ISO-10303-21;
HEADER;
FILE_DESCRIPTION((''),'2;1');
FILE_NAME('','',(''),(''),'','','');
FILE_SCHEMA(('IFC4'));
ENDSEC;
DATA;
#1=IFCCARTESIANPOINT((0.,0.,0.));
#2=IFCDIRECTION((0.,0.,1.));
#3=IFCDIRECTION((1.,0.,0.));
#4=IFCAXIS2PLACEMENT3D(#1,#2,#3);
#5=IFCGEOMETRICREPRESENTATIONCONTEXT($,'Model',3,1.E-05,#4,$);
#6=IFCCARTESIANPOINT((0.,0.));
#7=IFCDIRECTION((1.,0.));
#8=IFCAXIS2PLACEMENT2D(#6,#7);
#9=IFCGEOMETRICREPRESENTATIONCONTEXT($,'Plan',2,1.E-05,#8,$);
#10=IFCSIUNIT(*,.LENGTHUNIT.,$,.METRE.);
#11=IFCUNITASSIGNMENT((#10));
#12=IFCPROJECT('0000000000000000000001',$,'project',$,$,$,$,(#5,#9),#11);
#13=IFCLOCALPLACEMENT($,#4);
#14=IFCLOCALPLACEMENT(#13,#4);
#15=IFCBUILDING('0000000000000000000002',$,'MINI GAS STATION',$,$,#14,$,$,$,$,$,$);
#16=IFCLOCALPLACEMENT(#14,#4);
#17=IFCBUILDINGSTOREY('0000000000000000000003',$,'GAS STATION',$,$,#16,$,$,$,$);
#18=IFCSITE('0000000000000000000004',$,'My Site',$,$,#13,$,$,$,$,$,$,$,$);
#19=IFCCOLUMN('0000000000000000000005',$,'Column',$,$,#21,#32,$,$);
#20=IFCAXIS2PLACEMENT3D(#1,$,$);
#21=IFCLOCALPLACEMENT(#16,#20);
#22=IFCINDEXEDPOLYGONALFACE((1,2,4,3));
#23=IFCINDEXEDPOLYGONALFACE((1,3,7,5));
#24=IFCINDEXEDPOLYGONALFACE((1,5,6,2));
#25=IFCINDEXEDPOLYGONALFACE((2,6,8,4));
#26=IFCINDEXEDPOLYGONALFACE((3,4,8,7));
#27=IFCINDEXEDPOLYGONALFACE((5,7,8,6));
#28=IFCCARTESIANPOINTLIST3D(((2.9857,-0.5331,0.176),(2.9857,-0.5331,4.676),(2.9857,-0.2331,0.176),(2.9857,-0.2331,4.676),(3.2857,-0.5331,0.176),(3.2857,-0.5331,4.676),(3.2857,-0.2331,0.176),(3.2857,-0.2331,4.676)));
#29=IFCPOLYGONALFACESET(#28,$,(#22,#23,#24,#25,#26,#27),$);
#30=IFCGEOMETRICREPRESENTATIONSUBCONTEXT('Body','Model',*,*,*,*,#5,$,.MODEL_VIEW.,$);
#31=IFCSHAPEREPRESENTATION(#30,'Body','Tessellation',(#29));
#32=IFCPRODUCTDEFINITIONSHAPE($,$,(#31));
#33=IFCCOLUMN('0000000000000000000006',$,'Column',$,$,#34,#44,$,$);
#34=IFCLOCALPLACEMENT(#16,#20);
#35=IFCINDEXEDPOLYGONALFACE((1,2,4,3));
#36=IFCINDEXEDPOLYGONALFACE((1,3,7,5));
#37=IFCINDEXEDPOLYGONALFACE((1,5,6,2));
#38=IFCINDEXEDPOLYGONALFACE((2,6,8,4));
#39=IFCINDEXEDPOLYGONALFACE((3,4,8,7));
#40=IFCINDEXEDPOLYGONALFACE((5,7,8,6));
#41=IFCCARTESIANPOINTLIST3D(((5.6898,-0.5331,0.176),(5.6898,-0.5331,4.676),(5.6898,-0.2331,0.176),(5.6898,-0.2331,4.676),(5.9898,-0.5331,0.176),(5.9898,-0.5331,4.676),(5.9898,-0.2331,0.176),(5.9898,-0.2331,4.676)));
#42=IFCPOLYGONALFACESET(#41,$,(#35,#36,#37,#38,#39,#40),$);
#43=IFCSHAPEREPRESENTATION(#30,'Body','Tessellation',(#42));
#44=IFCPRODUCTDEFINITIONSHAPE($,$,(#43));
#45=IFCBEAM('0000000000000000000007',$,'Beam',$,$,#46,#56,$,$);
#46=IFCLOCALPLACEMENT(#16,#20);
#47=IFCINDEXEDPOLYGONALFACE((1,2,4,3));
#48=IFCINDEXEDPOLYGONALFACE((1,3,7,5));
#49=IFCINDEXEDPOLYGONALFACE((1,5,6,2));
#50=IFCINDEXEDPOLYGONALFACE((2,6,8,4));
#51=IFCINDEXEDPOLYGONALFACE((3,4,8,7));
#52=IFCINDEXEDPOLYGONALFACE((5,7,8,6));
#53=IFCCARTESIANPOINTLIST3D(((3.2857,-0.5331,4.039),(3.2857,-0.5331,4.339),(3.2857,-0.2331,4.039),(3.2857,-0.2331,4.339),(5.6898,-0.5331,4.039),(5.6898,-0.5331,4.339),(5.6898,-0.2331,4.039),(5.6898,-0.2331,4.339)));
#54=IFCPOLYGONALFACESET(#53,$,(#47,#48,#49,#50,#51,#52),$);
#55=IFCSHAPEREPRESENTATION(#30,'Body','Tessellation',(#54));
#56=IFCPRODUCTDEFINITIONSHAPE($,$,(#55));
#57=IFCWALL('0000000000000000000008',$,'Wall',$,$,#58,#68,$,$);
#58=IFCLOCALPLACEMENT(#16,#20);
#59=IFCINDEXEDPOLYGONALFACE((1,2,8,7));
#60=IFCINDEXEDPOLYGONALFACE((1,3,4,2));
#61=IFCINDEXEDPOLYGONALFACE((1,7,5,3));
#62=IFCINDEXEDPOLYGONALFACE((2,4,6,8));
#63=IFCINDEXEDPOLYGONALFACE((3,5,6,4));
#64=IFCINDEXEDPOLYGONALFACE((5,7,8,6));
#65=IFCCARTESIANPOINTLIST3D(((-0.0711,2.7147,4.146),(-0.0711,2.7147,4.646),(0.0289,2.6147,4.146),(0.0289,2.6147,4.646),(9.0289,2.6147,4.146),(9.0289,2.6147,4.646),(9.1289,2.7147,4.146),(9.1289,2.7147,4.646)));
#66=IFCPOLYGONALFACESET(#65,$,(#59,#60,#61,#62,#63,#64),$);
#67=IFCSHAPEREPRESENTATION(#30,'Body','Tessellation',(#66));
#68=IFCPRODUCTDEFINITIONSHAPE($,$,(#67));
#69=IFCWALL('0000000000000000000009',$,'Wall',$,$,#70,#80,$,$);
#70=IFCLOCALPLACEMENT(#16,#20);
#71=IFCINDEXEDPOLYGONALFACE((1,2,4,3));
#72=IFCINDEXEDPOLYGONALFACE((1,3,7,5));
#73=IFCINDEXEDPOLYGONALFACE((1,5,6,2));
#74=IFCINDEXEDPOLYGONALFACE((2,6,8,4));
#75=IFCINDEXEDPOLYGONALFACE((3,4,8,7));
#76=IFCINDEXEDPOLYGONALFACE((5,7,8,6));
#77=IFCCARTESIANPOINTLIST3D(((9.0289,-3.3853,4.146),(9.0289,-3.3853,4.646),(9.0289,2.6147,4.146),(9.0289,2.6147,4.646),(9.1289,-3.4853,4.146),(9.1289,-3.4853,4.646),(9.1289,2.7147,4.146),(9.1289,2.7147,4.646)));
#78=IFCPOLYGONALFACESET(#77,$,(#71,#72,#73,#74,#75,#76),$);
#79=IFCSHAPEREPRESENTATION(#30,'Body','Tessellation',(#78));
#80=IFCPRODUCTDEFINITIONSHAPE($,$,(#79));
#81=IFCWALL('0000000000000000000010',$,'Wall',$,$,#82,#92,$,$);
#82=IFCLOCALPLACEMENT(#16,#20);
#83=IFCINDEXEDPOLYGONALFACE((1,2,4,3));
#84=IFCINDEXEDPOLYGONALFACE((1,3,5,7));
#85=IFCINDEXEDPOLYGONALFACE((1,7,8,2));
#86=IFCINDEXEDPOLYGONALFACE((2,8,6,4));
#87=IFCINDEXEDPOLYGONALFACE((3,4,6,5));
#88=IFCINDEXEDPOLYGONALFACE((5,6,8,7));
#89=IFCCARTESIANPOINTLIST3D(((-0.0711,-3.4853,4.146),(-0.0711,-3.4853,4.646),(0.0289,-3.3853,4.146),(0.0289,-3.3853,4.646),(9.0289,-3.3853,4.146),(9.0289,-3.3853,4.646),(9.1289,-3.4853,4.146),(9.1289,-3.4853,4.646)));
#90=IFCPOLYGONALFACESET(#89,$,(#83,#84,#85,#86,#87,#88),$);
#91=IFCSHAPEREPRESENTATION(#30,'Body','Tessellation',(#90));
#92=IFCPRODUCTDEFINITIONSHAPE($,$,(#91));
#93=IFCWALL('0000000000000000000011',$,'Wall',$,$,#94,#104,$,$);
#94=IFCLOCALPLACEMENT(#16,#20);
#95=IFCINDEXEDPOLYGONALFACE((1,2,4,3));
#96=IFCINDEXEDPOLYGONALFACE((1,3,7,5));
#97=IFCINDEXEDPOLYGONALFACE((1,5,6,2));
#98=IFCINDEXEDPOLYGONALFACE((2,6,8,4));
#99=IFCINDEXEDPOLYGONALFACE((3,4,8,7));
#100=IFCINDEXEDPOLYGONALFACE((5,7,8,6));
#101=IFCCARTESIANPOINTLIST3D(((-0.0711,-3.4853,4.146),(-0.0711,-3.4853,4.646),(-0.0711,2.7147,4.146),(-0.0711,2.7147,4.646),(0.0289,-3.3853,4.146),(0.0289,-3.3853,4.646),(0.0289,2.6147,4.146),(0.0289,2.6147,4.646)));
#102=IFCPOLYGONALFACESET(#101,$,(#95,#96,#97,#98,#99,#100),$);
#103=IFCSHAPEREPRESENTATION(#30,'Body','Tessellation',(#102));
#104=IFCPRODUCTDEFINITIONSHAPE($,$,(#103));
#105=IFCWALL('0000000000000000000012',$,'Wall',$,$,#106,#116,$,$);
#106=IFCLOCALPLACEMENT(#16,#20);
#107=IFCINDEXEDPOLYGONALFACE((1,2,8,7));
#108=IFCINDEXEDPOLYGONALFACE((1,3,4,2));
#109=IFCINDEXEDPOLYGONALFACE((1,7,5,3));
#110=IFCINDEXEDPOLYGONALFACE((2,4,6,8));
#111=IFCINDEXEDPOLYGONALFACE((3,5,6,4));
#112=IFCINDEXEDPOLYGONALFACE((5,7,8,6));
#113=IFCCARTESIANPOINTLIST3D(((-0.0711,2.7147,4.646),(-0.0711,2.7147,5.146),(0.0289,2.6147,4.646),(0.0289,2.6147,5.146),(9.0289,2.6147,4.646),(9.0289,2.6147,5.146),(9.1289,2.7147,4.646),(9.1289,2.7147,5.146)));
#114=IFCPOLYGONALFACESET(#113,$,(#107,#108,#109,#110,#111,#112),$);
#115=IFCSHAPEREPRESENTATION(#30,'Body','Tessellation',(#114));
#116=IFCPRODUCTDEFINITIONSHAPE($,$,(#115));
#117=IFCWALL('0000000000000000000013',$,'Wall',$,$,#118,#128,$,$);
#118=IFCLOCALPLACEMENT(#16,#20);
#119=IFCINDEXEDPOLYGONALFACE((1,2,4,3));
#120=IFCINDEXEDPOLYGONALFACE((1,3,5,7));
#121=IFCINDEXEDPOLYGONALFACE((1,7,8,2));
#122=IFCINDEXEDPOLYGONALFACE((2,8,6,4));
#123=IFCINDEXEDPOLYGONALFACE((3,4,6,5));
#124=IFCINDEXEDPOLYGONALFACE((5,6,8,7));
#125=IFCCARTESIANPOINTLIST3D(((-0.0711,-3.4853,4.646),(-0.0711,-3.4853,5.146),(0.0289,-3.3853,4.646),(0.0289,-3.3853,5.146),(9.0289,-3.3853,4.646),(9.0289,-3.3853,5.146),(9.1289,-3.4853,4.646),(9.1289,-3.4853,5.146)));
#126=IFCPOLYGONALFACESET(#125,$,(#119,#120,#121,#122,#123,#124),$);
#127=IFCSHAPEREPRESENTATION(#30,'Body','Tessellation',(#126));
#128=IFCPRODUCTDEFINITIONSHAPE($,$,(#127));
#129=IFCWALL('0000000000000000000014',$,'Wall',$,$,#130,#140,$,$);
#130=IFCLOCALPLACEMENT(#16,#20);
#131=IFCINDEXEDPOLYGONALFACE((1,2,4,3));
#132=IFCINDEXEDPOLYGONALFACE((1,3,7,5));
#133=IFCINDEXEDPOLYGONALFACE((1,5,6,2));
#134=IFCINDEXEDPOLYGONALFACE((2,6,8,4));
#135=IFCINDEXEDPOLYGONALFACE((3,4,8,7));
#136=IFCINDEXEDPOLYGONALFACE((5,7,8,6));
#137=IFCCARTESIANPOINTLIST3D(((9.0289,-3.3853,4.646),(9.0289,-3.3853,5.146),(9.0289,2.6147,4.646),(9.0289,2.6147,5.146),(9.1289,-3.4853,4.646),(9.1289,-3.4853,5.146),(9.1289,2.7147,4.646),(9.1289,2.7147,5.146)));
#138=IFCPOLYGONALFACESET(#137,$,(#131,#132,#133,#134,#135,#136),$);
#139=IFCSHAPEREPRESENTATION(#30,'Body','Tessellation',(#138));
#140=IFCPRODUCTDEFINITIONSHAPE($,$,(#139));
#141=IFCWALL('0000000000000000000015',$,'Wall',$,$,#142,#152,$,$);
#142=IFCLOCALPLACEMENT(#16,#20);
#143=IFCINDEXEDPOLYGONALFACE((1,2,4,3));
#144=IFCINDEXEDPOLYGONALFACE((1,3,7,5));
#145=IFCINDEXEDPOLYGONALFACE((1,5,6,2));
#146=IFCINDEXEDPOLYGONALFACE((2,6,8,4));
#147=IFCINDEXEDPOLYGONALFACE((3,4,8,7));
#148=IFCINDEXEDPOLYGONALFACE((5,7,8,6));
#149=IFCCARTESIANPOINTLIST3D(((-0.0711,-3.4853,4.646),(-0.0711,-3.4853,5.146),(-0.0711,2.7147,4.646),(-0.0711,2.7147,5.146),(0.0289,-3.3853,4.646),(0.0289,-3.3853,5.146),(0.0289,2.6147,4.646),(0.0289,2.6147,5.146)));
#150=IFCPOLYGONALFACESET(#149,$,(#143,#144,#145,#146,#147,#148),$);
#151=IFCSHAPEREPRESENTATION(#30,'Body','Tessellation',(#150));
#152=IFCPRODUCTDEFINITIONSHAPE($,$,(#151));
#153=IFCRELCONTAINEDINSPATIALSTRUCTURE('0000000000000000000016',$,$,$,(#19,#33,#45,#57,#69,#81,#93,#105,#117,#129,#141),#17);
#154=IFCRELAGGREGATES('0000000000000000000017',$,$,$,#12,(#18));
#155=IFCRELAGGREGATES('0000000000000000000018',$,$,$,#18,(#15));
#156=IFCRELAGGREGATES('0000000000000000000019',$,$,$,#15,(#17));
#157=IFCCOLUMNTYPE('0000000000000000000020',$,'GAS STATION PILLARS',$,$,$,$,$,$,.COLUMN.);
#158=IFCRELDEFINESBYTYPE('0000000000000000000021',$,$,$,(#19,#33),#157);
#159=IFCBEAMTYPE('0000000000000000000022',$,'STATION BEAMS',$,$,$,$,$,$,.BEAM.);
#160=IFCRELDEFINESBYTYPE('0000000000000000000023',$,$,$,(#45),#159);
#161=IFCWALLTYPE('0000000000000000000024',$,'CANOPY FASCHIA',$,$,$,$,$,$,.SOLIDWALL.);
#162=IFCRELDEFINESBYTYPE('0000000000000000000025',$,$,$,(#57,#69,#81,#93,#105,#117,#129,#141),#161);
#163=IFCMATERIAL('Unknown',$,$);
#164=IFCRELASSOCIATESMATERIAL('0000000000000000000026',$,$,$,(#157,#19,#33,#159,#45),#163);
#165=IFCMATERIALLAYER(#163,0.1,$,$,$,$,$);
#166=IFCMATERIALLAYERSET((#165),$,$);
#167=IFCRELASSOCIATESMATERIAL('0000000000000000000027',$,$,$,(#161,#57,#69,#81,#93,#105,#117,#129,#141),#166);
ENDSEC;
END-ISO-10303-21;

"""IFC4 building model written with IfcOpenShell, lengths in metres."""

from ifc_helpers import new_model, si_unit, frame, origin_with_axes, origin_2d_with_axis, place, context, subcontext, project, spatial, line, indexed_curve, rectangle, outline, extrude, material, layer, layer_set, layer_usage, material_profile, profile_set, profile_usage, type_object, element, save


model = new_model("IFC4")

# Units and contexts
model_context = context("Model", 3, precision=1e-05, world=origin_with_axes())
plan_context = context("Plan", 2, precision=1e-05, world=origin_2d_with_axis())
body_context = subcontext(model_context, "Body", "Model", "MODEL_VIEW")
ifc_project = project(units=[si_unit("LENGTHUNIT", "METRE")], contexts=[model_context, plan_context])

# Site, building, storey
site_placement = place(None, origin_with_axes())
site = spatial("IfcSite", under=ifc_project, at=site_placement, Name="My Site")
building_placement = place(site_placement, origin_with_axes())
building = spatial("IfcBuilding", under=site, at=building_placement, Name="MINI GAS STATION")
storey_placement = place(building_placement, origin_with_axes())
storey = spatial("IfcBuildingStorey", under=building, at=storey_placement, Name="GAS STATION")

# Columns
ifc_material = material(Name="Unknown")
ifc_material_profile_1 = material_profile(ifc_material, rectangle(XDim=0.3, YDim=0.3))
ifc_profile_set_1 = profile_set([ifc_material_profile_1])
ifc_profile_usage_1 = profile_usage(ifc_profile_set_1, cardinal=5)
column_type = type_object("IfcColumnType", Name="GAS STATION PILLARS", PredefinedType="COLUMN", material=ifc_profile_set_1)
column_1_placement = place(storey_placement, frame((3.1357, -0.3831, 0.176), z_axis=(0.0, 0.0, 1.0), x_axis=(1.0, 0.0, 0.0)))
element("IfcColumn", 1, at=column_1_placement, inside=storey, type_object=column_type, material=ifc_profile_usage_1, Name="Column", context=body_context, shape_type="SweptSolid", body=[
    extrude(rectangle(XDim=0.3, YDim=0.3), origin_with_axes(), (0.0, 0.0, 1.0), 4.5),
])
ifc_profile_usage_2 = profile_usage(ifc_profile_set_1, cardinal=5)
column_2_placement = place(storey_placement, frame((5.8398, -0.3831, 0.176), z_axis=(0.0, 0.0, 1.0), x_axis=(1.0, 0.0, 0.0)))
element("IfcColumn", 2, at=column_2_placement, inside=storey, type_object=column_type, material=ifc_profile_usage_2, Name="Column", context=body_context, shape_type="SweptSolid", body=[
    extrude(rectangle(XDim=0.3, YDim=0.3), origin_with_axes(), (0.0, 0.0, 1.0), 4.5),
])

# Beam
ifc_material_profile_2 = material_profile(ifc_material, rectangle(XDim=0.3, YDim=0.3))
ifc_profile_set_2 = profile_set([ifc_material_profile_2])
ifc_profile_usage_3 = profile_usage(ifc_profile_set_2, cardinal=5)
beam_type = type_object("IfcBeamType", Name="STATION BEAMS", PredefinedType="BEAM", material=ifc_profile_set_2)
beam_placement = place(storey_placement, frame((3.2857, -0.3831, 4.189), z_axis=(1.0, 0.0, 0.0), x_axis=(0.0, 1.0, 0.0)))
element("IfcBeam", 3, at=beam_placement, inside=storey, type_object=beam_type, material=ifc_profile_usage_3, Name="Beam", context=body_context, shape_type="SweptSolid", body=[
    extrude(rectangle(XDim=0.3, YDim=0.3), origin_with_axes(), (0.0, 0.0, 1.0), 2.4041),
])

# Walls
ifc_layer_1 = layer(ifc_material, 0.1)
ifc_layer_set_1 = layer_set([ifc_layer_1])
ifc_layer_usage_1 = layer_usage(ifc_layer_set_1, "AXIS2", "POSITIVE", 0.0)
wall_type = type_object("IfcWallType", Name="CANOPY FASCHIA", PredefinedType="SOLIDWALL", material=ifc_layer_set_1)
wall_1_placement = place(storey_placement, frame((0.0289, 2.6147, 4.146), z_axis=(0.0, 0.0, 1.0), x_axis=(1.0, 0.0, 0.0)))
element("IfcWall", 4, at=wall_1_placement, inside=storey, type_object=wall_type, material=ifc_layer_usage_1, Name="Wall", context=body_context, shape_type="SweptSolid", body=[
    extrude(outline(indexed_curve([(0.0, 0.0), (-0.1, 0.1), (9.1, 0.1), (9.0, 0.0)], segments=[line(1, 2, 3, 4, 1)])), origin_with_axes(), (0.0, 0.0, 1.0), 0.5),
])
ifc_layer_usage_2 = layer_usage(ifc_layer_set_1, "AXIS2", "POSITIVE", 0.0)
wall_2_placement = place(storey_placement, frame((9.0289, 2.6147, 4.146), z_axis=(0.0, 0.0, 1.0), x_axis=(0.0, -1.0, 0.0)))
element("IfcWall", 5, at=wall_2_placement, inside=storey, type_object=wall_type, material=ifc_layer_usage_2, Name="Wall", context=body_context, shape_type="SweptSolid", body=[
    extrude(outline(indexed_curve([(0.0, 0.0), (-0.1, 0.1), (6.1, 0.1), (6.0, 0.0)], segments=[line(1, 2, 3, 4, 1)])), origin_with_axes(), (0.0, 0.0, 1.0), 0.5),
])
ifc_layer_usage_3 = layer_usage(ifc_layer_set_1, "AXIS2", "POSITIVE", 0.0)
wall_3_placement = place(storey_placement, frame((9.0289, -3.3853, 4.146), z_axis=(0.0, 0.0, 1.0), x_axis=(-1.0, 0.0, 0.0)))
element("IfcWall", 6, at=wall_3_placement, inside=storey, type_object=wall_type, material=ifc_layer_usage_3, Name="Wall", context=body_context, shape_type="SweptSolid", body=[
    extrude(outline(indexed_curve([(0.0, 0.0), (-0.1, 0.1), (9.1, 0.1), (9.0, 0.0)], segments=[line(1, 2, 3, 4, 1)])), origin_with_axes(), (0.0, 0.0, 1.0), 0.5),
])
ifc_layer_usage_4 = layer_usage(ifc_layer_set_1, "AXIS2", "POSITIVE", 0.0)
wall_4_placement = place(storey_placement, frame((0.0289, -3.3853, 4.146), z_axis=(0.0, 0.0, 1.0), x_axis=(0.0, 1.0, 0.0)))
element("IfcWall", 7, at=wall_4_placement, inside=storey, type_object=wall_type, material=ifc_layer_usage_4, Name="Wall", context=body_context, shape_type="SweptSolid", body=[
    extrude(outline(indexed_curve([(0.0, 0.0), (-0.1, 0.1), (6.1, 0.1), (6.0, 0.0)], segments=[line(1, 2, 3, 4, 1)])), origin_with_axes(), (0.0, 0.0, 1.0), 0.5),
])
ifc_layer_usage_5 = layer_usage(ifc_layer_set_1, "AXIS2", "POSITIVE", 0.0)
wall_5_placement = place(storey_placement, frame((0.0289, 2.6147, 4.646), z_axis=(0.0, 0.0, 1.0), x_axis=(1.0, 0.0, 0.0)))
element("IfcWall", 8, at=wall_5_placement, inside=storey, type_object=wall_type, material=ifc_layer_usage_5, Name="Wall", context=body_context, shape_type="SweptSolid", body=[
    extrude(outline(indexed_curve([(0.0, 0.0), (-0.1, 0.1), (9.1, 0.1), (9.0, 0.0)], segments=[line(1, 2, 3, 4, 1)])), origin_with_axes(), (0.0, 0.0, 1.0), 0.5),
])
ifc_layer_usage_6 = layer_usage(ifc_layer_set_1, "AXIS2", "POSITIVE", 0.0)
wall_6_placement = place(storey_placement, frame((9.0289, -3.3853, 4.646), z_axis=(0.0, 0.0, 1.0), x_axis=(-1.0, 0.0, 0.0)))
element("IfcWall", 9, at=wall_6_placement, inside=storey, type_object=wall_type, material=ifc_layer_usage_6, Name="Wall", context=body_context, shape_type="SweptSolid", body=[
    extrude(outline(indexed_curve([(0.0, 0.0), (-0.1, 0.1), (9.1, 0.1), (9.0, 0.0)], segments=[line(1, 2, 3, 4, 1)])), origin_with_axes(), (0.0, 0.0, 1.0), 0.5),
])
ifc_layer_usage_7 = layer_usage(ifc_layer_set_1, "AXIS2", "POSITIVE", 0.0)
wall_7_placement = place(storey_placement, frame((9.0289, 2.6147, 4.646), z_axis=(0.0, 0.0, 1.0), x_axis=(0.0, -1.0, 0.0)))
element("IfcWall", 10, at=wall_7_placement, inside=storey, type_object=wall_type, material=ifc_layer_usage_7, Name="Wall", context=body_context, shape_type="SweptSolid", body=[
    extrude(outline(indexed_curve([(0.0, 0.0), (-0.1, 0.1), (6.1, 0.1), (6.0, 0.0)], segments=[line(1, 2, 3, 4, 1)])), origin_with_axes(), (0.0, 0.0, 1.0), 0.5),
])
ifc_layer_usage_8 = layer_usage(ifc_layer_set_1, "AXIS2", "POSITIVE", 0.0)
wall_8_placement = place(storey_placement, frame((0.0289, -3.3853, 4.646), z_axis=(0.0, 0.0, 1.0), x_axis=(0.0, 1.0, 0.0)))
element("IfcWall", 11, at=wall_8_placement, inside=storey, type_object=wall_type, material=ifc_layer_usage_8, Name="Wall", context=body_context, shape_type="SweptSolid", body=[
    extrude(outline(indexed_curve([(0.0, 0.0), (-0.1, 0.1), (6.1, 0.1), (6.0, 0.0)], segments=[line(1, 2, 3, 4, 1)])), origin_with_axes(), (0.0, 0.0, 1.0), 0.5),
])

save(model, "model.ifc")
